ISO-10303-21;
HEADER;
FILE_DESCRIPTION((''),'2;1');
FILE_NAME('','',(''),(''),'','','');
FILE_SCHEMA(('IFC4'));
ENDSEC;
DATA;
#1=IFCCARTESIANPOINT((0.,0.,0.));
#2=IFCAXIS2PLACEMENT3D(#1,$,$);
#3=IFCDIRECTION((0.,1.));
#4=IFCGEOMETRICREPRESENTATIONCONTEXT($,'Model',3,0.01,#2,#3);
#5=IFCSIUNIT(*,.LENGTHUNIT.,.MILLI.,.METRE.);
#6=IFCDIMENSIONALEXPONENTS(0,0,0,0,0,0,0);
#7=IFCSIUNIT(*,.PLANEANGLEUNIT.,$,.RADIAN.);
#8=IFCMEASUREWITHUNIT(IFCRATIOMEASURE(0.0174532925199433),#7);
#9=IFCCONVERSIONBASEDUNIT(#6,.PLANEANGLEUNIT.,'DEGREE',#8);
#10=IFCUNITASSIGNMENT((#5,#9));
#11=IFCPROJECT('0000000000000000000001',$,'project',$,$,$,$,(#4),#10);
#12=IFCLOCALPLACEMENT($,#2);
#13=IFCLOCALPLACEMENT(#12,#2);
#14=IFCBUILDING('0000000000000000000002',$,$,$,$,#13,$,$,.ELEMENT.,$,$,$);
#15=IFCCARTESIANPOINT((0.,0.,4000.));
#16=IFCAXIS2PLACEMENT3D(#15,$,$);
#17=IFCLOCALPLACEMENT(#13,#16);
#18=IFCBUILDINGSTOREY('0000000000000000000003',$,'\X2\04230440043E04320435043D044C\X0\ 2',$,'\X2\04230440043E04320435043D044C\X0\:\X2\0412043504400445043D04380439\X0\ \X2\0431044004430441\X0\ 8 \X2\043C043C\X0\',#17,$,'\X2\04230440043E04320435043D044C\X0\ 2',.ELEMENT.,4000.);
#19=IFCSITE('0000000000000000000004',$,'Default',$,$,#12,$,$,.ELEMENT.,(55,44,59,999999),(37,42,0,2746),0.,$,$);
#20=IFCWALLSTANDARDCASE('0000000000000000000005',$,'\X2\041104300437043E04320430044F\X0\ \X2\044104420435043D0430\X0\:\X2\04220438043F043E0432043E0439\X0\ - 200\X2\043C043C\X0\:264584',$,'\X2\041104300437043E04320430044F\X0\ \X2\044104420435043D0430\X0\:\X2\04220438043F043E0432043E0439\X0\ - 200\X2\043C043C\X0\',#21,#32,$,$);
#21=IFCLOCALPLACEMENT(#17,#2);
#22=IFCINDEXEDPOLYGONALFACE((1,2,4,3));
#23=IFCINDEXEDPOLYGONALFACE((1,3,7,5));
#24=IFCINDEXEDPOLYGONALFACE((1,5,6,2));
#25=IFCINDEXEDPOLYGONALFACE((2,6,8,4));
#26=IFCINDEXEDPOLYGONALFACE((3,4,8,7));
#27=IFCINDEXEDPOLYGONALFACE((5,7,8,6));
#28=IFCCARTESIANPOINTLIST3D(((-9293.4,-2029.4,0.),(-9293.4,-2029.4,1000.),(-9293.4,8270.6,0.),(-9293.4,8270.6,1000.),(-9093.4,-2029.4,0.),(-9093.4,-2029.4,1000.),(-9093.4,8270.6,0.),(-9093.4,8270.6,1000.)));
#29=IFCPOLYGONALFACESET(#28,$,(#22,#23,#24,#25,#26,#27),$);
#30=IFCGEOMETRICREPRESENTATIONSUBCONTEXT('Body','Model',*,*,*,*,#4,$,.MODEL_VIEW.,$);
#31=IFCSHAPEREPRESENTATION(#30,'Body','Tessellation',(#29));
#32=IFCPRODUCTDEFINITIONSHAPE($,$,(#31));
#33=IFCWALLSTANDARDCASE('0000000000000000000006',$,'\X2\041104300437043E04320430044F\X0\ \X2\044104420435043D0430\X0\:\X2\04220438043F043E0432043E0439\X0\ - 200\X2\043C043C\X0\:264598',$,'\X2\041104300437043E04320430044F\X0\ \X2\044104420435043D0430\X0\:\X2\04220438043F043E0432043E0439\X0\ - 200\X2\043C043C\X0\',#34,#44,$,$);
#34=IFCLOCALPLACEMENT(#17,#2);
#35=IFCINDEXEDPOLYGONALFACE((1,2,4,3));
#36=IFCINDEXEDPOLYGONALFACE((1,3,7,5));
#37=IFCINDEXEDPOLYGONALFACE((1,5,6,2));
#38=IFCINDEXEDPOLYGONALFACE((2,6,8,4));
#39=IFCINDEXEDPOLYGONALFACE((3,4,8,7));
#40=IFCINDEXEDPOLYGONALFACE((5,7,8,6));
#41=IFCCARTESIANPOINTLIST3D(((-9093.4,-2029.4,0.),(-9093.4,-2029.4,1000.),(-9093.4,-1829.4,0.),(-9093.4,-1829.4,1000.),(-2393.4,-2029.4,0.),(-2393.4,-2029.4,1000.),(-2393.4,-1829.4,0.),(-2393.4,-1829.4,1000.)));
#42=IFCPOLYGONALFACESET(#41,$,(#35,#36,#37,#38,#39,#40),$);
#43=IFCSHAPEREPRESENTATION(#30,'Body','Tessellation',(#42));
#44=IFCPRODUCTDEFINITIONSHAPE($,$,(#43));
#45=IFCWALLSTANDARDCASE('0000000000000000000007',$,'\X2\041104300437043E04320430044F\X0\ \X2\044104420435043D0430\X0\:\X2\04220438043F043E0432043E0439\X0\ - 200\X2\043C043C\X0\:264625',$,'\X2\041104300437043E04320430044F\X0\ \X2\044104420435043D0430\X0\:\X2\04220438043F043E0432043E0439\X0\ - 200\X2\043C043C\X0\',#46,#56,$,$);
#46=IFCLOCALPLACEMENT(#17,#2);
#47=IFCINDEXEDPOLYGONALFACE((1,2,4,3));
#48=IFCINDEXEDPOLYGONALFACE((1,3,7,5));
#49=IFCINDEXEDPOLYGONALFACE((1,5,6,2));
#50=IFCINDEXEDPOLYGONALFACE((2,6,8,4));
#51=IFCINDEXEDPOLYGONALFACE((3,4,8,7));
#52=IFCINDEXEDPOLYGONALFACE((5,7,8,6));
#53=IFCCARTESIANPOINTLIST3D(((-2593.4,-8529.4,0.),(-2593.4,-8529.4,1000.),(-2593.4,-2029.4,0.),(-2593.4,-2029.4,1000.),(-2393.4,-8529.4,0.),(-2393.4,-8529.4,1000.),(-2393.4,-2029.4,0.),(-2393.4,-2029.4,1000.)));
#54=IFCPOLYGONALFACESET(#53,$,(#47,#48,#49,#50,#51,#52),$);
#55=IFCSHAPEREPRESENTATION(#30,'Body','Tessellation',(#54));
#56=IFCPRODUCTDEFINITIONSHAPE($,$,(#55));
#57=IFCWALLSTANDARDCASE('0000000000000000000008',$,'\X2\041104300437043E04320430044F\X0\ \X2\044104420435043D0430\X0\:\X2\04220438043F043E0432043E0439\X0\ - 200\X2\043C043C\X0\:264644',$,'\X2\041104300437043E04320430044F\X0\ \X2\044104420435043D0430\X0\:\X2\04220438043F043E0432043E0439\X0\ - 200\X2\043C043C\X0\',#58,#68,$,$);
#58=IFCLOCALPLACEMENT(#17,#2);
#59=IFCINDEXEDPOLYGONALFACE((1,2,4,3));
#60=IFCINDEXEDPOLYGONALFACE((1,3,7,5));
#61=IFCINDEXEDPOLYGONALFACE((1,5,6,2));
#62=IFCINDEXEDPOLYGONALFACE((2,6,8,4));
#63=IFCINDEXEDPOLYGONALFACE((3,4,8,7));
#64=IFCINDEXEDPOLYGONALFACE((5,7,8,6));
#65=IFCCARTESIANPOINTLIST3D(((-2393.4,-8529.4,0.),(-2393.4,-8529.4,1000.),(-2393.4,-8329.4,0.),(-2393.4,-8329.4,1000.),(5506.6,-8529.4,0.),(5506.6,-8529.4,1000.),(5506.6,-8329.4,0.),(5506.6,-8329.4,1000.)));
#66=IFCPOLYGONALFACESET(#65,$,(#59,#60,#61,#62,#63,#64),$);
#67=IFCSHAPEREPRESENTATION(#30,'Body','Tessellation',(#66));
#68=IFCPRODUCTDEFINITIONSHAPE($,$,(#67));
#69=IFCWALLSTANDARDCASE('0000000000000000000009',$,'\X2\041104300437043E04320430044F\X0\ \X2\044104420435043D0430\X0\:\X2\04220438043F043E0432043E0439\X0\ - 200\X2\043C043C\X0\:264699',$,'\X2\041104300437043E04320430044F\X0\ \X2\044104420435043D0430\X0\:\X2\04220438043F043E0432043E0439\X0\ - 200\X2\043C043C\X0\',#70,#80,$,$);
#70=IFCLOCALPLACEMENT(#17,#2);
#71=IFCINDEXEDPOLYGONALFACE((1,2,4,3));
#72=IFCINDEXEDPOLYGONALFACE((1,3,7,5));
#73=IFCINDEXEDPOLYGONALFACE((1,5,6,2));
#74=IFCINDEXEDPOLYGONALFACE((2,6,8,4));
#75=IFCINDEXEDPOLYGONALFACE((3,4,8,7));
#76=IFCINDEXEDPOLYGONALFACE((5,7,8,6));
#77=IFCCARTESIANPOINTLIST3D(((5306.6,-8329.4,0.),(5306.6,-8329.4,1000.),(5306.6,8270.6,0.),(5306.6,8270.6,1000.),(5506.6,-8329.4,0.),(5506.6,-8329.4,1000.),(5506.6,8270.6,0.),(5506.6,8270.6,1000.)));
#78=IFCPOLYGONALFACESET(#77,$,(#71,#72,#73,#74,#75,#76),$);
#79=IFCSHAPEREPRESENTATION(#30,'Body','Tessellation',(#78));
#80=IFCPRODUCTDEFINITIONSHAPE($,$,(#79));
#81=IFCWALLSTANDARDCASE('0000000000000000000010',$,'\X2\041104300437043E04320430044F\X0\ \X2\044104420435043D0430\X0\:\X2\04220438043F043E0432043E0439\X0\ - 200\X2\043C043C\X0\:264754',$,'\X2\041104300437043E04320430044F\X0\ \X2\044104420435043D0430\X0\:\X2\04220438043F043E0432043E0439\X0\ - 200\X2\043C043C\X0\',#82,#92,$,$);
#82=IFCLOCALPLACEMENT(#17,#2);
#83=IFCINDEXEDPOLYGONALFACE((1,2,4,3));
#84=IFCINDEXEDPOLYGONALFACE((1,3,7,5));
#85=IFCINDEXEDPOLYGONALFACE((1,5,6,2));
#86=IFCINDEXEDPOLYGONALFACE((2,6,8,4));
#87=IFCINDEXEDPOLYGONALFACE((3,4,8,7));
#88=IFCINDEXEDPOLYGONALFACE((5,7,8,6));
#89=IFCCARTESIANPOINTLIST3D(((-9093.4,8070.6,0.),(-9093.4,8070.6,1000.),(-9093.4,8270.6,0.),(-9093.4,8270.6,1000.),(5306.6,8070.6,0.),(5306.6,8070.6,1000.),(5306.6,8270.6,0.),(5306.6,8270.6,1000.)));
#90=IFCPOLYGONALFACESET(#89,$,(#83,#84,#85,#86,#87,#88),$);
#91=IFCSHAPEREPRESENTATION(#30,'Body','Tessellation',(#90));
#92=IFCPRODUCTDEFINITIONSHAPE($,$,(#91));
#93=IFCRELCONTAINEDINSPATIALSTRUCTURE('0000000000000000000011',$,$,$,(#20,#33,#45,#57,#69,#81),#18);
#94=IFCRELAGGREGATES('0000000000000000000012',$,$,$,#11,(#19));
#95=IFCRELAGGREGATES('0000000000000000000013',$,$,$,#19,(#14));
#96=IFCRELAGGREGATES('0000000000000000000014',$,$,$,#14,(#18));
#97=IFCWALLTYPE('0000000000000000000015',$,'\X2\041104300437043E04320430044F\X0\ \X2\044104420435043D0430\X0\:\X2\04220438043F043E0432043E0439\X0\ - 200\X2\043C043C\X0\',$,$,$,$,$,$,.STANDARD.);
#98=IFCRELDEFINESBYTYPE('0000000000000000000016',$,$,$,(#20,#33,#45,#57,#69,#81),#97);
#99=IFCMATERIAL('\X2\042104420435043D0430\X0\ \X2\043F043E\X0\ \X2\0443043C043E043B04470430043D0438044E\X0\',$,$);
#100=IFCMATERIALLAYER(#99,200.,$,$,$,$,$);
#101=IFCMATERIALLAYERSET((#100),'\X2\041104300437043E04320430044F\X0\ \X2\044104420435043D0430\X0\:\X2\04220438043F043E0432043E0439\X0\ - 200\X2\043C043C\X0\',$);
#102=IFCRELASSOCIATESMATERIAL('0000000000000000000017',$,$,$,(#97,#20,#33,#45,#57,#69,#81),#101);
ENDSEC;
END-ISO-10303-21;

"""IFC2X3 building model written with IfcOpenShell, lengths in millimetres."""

from ifc_helpers import new_model, entity, si_unit, converted_unit, direction, frame, frame_2d, origin, place, context, subcontext, project, spatial, rectangle, extrude, clip, halfspace, material, layer, layer_set, layer_usage, type_object, element, save


model = new_model("IFC2X3")

# Units and contexts
model_context = context("Model", 3, precision=0.01, world=origin(), true_north=direction((0.0, 1.0)))
body_context = subcontext(model_context, "Body", "Model", "MODEL_VIEW")
ifc_project = project(units=[si_unit("LENGTHUNIT", "METRE", prefix="MILLI"), converted_unit("PLANEANGLEUNIT", "DEGREE", entity("IfcRatioMeasure", 0.0174532925199433), si_unit("PLANEANGLEUNIT", "RADIAN"), dimensions=[0, 0, 0, 0, 0, 0, 0])], contexts=[model_context])

# Site, building, storey
site_placement = place(None, origin())
site = spatial("IfcSite", under=ifc_project, at=site_placement, Name="Default", CompositionType="ELEMENT", RefLatitude=(55, 44, 59, 999999), RefLongitude=(37, 42, 0, 2746), RefElevation=0.0)
building_placement = place(site_placement, origin())
building = spatial("IfcBuilding", under=site, at=building_placement, CompositionType="ELEMENT")
storey_placement = place(building_placement, frame((0.0, 0.0, 4000.0)))
storey = spatial("IfcBuildingStorey", under=building, at=storey_placement, Name="Уровень 2", ObjectType="Уровень:Верхний брус 8 мм", LongName="Уровень 2", CompositionType="ELEMENT", Elevation=4000.0)

# Walls
ifc_material = material(Name="Стена по умолчанию")
ifc_layer = layer(ifc_material, 200.0)
ifc_layer_set = layer_set([ifc_layer], Name="Базовая стена:Типовой - 200мм")
ifc_layer_usage_1 = layer_usage(ifc_layer_set, "AXIS2", "NEGATIVE", 100.0)
wall_type = type_object("IfcWallType", Name="Базовая стена:Типовой - 200мм", PredefinedType="STANDARD", material=ifc_layer_set)
wall_1_placement = place(storey_placement, frame((-9193.4, 8270.6, 0.0), z_axis=(0.0, 0.0, 1.0), x_axis=(0.0, -1.0, 0.0)))
element("IfcWallStandardCase", 1, at=wall_1_placement, inside=storey, type_object=wall_type, material=ifc_layer_usage_1, Name="Базовая стена:Типовой - 200мм:264584", ObjectType="Базовая стена:Типовой - 200мм", context=body_context, shape_type="Clipping", body=[
    clip(extrude(rectangle(XDim=10300.0, YDim=200.0, at=frame_2d((5150.0, 0.0), x_axis=(-1.0, 0.0))), origin(), (0.0, 0.0, 1.0), 1000.0), halfspace(frame((0.0, 0.0, -8600.0)), True)),
])
ifc_layer_usage_2 = layer_usage(ifc_layer_set, "AXIS2", "NEGATIVE", 100.0)
wall_2_placement = place(storey_placement, frame((-9093.4, -1929.4, 0.0)))
element("IfcWallStandardCase", 2, at=wall_2_placement, inside=storey, type_object=wall_type, material=ifc_layer_usage_2, Name="Базовая стена:Типовой - 200мм:264598", ObjectType="Базовая стена:Типовой - 200мм", context=body_context, shape_type="Clipping", body=[
    clip(extrude(rectangle(XDim=6700.0, YDim=200.0, at=frame_2d((3350.0, 0.0), x_axis=(-1.0, 0.0))), origin(), (0.0, 0.0, 1.0), 1000.0), halfspace(frame((0.0, 0.0, -8600.0)), True)),
])
ifc_layer_usage_3 = layer_usage(ifc_layer_set, "AXIS2", "NEGATIVE", 100.0)
wall_3_placement = place(storey_placement, frame((-2493.4, -2029.4, 0.0), z_axis=(0.0, 0.0, 1.0), x_axis=(0.0, -1.0, 0.0)))
element("IfcWallStandardCase", 3, at=wall_3_placement, inside=storey, type_object=wall_type, material=ifc_layer_usage_3, Name="Базовая стена:Типовой - 200мм:264625", ObjectType="Базовая стена:Типовой - 200мм", context=body_context, shape_type="Clipping", body=[
    clip(extrude(rectangle(XDim=6500.0, YDim=200.0, at=frame_2d((3250.0, 0.0), x_axis=(-1.0, 0.0))), origin(), (0.0, 0.0, 1.0), 1000.0), halfspace(frame((0.0, 0.0, -8600.0)), True)),
])
ifc_layer_usage_4 = layer_usage(ifc_layer_set, "AXIS2", "NEGATIVE", 100.0)
wall_4_placement = place(storey_placement, frame((-2393.4, -8429.4, 0.0)))
element("IfcWallStandardCase", 4, at=wall_4_placement, inside=storey, type_object=wall_type, material=ifc_layer_usage_4, Name="Базовая стена:Типовой - 200мм:264644", ObjectType="Базовая стена:Типовой - 200мм", context=body_context, shape_type="Clipping", body=[
    clip(extrude(rectangle(XDim=7900.0, YDim=200.0, at=frame_2d((3950.0, 0.0), x_axis=(-1.0, 0.0))), origin(), (0.0, 0.0, 1.0), 1000.0), halfspace(frame((0.0, 0.0, -8600.0)), True)),
])
ifc_layer_usage_5 = layer_usage(ifc_layer_set, "AXIS2", "NEGATIVE", 100.0)
wall_5_placement = place(storey_placement, frame((5406.6, -8329.4, 0.0), z_axis=(0.0, 0.0, 1.0), x_axis=(0.0, 1.0, 0.0)))
element("IfcWallStandardCase", 5, at=wall_5_placement, inside=storey, type_object=wall_type, material=ifc_layer_usage_5, Name="Базовая стена:Типовой - 200мм:264699", ObjectType="Базовая стена:Типовой - 200мм", context=body_context, shape_type="Clipping", body=[
    clip(extrude(rectangle(XDim=16600.0, YDim=200.0, at=frame_2d((8300.0, 0.0), x_axis=(-1.0, 0.0))), origin(), (0.0, 0.0, 1.0), 1000.0), halfspace(frame((0.0, 0.0, -8600.0)), True)),
])
ifc_layer_usage_6 = layer_usage(ifc_layer_set, "AXIS2", "NEGATIVE", 100.0)
wall_6_placement = place(storey_placement, frame((5306.6, 8170.6, 0.0), z_axis=(0.0, 0.0, 1.0), x_axis=(-1.0, 0.0, 0.0)))
element("IfcWallStandardCase", 6, at=wall_6_placement, inside=storey, type_object=wall_type, material=ifc_layer_usage_6, Name="Базовая стена:Типовой - 200мм:264754", ObjectType="Базовая стена:Типовой - 200мм", context=body_context, shape_type="Clipping", body=[
    clip(extrude(rectangle(XDim=14400.0, YDim=200.0, at=frame_2d((7200.0, 0.0), x_axis=(-1.0, 0.0))), origin(), (0.0, 0.0, 1.0), 1000.0), halfspace(frame((0.0, 0.0, -8600.0)), True)),
])

save(model, "model.ifc")
